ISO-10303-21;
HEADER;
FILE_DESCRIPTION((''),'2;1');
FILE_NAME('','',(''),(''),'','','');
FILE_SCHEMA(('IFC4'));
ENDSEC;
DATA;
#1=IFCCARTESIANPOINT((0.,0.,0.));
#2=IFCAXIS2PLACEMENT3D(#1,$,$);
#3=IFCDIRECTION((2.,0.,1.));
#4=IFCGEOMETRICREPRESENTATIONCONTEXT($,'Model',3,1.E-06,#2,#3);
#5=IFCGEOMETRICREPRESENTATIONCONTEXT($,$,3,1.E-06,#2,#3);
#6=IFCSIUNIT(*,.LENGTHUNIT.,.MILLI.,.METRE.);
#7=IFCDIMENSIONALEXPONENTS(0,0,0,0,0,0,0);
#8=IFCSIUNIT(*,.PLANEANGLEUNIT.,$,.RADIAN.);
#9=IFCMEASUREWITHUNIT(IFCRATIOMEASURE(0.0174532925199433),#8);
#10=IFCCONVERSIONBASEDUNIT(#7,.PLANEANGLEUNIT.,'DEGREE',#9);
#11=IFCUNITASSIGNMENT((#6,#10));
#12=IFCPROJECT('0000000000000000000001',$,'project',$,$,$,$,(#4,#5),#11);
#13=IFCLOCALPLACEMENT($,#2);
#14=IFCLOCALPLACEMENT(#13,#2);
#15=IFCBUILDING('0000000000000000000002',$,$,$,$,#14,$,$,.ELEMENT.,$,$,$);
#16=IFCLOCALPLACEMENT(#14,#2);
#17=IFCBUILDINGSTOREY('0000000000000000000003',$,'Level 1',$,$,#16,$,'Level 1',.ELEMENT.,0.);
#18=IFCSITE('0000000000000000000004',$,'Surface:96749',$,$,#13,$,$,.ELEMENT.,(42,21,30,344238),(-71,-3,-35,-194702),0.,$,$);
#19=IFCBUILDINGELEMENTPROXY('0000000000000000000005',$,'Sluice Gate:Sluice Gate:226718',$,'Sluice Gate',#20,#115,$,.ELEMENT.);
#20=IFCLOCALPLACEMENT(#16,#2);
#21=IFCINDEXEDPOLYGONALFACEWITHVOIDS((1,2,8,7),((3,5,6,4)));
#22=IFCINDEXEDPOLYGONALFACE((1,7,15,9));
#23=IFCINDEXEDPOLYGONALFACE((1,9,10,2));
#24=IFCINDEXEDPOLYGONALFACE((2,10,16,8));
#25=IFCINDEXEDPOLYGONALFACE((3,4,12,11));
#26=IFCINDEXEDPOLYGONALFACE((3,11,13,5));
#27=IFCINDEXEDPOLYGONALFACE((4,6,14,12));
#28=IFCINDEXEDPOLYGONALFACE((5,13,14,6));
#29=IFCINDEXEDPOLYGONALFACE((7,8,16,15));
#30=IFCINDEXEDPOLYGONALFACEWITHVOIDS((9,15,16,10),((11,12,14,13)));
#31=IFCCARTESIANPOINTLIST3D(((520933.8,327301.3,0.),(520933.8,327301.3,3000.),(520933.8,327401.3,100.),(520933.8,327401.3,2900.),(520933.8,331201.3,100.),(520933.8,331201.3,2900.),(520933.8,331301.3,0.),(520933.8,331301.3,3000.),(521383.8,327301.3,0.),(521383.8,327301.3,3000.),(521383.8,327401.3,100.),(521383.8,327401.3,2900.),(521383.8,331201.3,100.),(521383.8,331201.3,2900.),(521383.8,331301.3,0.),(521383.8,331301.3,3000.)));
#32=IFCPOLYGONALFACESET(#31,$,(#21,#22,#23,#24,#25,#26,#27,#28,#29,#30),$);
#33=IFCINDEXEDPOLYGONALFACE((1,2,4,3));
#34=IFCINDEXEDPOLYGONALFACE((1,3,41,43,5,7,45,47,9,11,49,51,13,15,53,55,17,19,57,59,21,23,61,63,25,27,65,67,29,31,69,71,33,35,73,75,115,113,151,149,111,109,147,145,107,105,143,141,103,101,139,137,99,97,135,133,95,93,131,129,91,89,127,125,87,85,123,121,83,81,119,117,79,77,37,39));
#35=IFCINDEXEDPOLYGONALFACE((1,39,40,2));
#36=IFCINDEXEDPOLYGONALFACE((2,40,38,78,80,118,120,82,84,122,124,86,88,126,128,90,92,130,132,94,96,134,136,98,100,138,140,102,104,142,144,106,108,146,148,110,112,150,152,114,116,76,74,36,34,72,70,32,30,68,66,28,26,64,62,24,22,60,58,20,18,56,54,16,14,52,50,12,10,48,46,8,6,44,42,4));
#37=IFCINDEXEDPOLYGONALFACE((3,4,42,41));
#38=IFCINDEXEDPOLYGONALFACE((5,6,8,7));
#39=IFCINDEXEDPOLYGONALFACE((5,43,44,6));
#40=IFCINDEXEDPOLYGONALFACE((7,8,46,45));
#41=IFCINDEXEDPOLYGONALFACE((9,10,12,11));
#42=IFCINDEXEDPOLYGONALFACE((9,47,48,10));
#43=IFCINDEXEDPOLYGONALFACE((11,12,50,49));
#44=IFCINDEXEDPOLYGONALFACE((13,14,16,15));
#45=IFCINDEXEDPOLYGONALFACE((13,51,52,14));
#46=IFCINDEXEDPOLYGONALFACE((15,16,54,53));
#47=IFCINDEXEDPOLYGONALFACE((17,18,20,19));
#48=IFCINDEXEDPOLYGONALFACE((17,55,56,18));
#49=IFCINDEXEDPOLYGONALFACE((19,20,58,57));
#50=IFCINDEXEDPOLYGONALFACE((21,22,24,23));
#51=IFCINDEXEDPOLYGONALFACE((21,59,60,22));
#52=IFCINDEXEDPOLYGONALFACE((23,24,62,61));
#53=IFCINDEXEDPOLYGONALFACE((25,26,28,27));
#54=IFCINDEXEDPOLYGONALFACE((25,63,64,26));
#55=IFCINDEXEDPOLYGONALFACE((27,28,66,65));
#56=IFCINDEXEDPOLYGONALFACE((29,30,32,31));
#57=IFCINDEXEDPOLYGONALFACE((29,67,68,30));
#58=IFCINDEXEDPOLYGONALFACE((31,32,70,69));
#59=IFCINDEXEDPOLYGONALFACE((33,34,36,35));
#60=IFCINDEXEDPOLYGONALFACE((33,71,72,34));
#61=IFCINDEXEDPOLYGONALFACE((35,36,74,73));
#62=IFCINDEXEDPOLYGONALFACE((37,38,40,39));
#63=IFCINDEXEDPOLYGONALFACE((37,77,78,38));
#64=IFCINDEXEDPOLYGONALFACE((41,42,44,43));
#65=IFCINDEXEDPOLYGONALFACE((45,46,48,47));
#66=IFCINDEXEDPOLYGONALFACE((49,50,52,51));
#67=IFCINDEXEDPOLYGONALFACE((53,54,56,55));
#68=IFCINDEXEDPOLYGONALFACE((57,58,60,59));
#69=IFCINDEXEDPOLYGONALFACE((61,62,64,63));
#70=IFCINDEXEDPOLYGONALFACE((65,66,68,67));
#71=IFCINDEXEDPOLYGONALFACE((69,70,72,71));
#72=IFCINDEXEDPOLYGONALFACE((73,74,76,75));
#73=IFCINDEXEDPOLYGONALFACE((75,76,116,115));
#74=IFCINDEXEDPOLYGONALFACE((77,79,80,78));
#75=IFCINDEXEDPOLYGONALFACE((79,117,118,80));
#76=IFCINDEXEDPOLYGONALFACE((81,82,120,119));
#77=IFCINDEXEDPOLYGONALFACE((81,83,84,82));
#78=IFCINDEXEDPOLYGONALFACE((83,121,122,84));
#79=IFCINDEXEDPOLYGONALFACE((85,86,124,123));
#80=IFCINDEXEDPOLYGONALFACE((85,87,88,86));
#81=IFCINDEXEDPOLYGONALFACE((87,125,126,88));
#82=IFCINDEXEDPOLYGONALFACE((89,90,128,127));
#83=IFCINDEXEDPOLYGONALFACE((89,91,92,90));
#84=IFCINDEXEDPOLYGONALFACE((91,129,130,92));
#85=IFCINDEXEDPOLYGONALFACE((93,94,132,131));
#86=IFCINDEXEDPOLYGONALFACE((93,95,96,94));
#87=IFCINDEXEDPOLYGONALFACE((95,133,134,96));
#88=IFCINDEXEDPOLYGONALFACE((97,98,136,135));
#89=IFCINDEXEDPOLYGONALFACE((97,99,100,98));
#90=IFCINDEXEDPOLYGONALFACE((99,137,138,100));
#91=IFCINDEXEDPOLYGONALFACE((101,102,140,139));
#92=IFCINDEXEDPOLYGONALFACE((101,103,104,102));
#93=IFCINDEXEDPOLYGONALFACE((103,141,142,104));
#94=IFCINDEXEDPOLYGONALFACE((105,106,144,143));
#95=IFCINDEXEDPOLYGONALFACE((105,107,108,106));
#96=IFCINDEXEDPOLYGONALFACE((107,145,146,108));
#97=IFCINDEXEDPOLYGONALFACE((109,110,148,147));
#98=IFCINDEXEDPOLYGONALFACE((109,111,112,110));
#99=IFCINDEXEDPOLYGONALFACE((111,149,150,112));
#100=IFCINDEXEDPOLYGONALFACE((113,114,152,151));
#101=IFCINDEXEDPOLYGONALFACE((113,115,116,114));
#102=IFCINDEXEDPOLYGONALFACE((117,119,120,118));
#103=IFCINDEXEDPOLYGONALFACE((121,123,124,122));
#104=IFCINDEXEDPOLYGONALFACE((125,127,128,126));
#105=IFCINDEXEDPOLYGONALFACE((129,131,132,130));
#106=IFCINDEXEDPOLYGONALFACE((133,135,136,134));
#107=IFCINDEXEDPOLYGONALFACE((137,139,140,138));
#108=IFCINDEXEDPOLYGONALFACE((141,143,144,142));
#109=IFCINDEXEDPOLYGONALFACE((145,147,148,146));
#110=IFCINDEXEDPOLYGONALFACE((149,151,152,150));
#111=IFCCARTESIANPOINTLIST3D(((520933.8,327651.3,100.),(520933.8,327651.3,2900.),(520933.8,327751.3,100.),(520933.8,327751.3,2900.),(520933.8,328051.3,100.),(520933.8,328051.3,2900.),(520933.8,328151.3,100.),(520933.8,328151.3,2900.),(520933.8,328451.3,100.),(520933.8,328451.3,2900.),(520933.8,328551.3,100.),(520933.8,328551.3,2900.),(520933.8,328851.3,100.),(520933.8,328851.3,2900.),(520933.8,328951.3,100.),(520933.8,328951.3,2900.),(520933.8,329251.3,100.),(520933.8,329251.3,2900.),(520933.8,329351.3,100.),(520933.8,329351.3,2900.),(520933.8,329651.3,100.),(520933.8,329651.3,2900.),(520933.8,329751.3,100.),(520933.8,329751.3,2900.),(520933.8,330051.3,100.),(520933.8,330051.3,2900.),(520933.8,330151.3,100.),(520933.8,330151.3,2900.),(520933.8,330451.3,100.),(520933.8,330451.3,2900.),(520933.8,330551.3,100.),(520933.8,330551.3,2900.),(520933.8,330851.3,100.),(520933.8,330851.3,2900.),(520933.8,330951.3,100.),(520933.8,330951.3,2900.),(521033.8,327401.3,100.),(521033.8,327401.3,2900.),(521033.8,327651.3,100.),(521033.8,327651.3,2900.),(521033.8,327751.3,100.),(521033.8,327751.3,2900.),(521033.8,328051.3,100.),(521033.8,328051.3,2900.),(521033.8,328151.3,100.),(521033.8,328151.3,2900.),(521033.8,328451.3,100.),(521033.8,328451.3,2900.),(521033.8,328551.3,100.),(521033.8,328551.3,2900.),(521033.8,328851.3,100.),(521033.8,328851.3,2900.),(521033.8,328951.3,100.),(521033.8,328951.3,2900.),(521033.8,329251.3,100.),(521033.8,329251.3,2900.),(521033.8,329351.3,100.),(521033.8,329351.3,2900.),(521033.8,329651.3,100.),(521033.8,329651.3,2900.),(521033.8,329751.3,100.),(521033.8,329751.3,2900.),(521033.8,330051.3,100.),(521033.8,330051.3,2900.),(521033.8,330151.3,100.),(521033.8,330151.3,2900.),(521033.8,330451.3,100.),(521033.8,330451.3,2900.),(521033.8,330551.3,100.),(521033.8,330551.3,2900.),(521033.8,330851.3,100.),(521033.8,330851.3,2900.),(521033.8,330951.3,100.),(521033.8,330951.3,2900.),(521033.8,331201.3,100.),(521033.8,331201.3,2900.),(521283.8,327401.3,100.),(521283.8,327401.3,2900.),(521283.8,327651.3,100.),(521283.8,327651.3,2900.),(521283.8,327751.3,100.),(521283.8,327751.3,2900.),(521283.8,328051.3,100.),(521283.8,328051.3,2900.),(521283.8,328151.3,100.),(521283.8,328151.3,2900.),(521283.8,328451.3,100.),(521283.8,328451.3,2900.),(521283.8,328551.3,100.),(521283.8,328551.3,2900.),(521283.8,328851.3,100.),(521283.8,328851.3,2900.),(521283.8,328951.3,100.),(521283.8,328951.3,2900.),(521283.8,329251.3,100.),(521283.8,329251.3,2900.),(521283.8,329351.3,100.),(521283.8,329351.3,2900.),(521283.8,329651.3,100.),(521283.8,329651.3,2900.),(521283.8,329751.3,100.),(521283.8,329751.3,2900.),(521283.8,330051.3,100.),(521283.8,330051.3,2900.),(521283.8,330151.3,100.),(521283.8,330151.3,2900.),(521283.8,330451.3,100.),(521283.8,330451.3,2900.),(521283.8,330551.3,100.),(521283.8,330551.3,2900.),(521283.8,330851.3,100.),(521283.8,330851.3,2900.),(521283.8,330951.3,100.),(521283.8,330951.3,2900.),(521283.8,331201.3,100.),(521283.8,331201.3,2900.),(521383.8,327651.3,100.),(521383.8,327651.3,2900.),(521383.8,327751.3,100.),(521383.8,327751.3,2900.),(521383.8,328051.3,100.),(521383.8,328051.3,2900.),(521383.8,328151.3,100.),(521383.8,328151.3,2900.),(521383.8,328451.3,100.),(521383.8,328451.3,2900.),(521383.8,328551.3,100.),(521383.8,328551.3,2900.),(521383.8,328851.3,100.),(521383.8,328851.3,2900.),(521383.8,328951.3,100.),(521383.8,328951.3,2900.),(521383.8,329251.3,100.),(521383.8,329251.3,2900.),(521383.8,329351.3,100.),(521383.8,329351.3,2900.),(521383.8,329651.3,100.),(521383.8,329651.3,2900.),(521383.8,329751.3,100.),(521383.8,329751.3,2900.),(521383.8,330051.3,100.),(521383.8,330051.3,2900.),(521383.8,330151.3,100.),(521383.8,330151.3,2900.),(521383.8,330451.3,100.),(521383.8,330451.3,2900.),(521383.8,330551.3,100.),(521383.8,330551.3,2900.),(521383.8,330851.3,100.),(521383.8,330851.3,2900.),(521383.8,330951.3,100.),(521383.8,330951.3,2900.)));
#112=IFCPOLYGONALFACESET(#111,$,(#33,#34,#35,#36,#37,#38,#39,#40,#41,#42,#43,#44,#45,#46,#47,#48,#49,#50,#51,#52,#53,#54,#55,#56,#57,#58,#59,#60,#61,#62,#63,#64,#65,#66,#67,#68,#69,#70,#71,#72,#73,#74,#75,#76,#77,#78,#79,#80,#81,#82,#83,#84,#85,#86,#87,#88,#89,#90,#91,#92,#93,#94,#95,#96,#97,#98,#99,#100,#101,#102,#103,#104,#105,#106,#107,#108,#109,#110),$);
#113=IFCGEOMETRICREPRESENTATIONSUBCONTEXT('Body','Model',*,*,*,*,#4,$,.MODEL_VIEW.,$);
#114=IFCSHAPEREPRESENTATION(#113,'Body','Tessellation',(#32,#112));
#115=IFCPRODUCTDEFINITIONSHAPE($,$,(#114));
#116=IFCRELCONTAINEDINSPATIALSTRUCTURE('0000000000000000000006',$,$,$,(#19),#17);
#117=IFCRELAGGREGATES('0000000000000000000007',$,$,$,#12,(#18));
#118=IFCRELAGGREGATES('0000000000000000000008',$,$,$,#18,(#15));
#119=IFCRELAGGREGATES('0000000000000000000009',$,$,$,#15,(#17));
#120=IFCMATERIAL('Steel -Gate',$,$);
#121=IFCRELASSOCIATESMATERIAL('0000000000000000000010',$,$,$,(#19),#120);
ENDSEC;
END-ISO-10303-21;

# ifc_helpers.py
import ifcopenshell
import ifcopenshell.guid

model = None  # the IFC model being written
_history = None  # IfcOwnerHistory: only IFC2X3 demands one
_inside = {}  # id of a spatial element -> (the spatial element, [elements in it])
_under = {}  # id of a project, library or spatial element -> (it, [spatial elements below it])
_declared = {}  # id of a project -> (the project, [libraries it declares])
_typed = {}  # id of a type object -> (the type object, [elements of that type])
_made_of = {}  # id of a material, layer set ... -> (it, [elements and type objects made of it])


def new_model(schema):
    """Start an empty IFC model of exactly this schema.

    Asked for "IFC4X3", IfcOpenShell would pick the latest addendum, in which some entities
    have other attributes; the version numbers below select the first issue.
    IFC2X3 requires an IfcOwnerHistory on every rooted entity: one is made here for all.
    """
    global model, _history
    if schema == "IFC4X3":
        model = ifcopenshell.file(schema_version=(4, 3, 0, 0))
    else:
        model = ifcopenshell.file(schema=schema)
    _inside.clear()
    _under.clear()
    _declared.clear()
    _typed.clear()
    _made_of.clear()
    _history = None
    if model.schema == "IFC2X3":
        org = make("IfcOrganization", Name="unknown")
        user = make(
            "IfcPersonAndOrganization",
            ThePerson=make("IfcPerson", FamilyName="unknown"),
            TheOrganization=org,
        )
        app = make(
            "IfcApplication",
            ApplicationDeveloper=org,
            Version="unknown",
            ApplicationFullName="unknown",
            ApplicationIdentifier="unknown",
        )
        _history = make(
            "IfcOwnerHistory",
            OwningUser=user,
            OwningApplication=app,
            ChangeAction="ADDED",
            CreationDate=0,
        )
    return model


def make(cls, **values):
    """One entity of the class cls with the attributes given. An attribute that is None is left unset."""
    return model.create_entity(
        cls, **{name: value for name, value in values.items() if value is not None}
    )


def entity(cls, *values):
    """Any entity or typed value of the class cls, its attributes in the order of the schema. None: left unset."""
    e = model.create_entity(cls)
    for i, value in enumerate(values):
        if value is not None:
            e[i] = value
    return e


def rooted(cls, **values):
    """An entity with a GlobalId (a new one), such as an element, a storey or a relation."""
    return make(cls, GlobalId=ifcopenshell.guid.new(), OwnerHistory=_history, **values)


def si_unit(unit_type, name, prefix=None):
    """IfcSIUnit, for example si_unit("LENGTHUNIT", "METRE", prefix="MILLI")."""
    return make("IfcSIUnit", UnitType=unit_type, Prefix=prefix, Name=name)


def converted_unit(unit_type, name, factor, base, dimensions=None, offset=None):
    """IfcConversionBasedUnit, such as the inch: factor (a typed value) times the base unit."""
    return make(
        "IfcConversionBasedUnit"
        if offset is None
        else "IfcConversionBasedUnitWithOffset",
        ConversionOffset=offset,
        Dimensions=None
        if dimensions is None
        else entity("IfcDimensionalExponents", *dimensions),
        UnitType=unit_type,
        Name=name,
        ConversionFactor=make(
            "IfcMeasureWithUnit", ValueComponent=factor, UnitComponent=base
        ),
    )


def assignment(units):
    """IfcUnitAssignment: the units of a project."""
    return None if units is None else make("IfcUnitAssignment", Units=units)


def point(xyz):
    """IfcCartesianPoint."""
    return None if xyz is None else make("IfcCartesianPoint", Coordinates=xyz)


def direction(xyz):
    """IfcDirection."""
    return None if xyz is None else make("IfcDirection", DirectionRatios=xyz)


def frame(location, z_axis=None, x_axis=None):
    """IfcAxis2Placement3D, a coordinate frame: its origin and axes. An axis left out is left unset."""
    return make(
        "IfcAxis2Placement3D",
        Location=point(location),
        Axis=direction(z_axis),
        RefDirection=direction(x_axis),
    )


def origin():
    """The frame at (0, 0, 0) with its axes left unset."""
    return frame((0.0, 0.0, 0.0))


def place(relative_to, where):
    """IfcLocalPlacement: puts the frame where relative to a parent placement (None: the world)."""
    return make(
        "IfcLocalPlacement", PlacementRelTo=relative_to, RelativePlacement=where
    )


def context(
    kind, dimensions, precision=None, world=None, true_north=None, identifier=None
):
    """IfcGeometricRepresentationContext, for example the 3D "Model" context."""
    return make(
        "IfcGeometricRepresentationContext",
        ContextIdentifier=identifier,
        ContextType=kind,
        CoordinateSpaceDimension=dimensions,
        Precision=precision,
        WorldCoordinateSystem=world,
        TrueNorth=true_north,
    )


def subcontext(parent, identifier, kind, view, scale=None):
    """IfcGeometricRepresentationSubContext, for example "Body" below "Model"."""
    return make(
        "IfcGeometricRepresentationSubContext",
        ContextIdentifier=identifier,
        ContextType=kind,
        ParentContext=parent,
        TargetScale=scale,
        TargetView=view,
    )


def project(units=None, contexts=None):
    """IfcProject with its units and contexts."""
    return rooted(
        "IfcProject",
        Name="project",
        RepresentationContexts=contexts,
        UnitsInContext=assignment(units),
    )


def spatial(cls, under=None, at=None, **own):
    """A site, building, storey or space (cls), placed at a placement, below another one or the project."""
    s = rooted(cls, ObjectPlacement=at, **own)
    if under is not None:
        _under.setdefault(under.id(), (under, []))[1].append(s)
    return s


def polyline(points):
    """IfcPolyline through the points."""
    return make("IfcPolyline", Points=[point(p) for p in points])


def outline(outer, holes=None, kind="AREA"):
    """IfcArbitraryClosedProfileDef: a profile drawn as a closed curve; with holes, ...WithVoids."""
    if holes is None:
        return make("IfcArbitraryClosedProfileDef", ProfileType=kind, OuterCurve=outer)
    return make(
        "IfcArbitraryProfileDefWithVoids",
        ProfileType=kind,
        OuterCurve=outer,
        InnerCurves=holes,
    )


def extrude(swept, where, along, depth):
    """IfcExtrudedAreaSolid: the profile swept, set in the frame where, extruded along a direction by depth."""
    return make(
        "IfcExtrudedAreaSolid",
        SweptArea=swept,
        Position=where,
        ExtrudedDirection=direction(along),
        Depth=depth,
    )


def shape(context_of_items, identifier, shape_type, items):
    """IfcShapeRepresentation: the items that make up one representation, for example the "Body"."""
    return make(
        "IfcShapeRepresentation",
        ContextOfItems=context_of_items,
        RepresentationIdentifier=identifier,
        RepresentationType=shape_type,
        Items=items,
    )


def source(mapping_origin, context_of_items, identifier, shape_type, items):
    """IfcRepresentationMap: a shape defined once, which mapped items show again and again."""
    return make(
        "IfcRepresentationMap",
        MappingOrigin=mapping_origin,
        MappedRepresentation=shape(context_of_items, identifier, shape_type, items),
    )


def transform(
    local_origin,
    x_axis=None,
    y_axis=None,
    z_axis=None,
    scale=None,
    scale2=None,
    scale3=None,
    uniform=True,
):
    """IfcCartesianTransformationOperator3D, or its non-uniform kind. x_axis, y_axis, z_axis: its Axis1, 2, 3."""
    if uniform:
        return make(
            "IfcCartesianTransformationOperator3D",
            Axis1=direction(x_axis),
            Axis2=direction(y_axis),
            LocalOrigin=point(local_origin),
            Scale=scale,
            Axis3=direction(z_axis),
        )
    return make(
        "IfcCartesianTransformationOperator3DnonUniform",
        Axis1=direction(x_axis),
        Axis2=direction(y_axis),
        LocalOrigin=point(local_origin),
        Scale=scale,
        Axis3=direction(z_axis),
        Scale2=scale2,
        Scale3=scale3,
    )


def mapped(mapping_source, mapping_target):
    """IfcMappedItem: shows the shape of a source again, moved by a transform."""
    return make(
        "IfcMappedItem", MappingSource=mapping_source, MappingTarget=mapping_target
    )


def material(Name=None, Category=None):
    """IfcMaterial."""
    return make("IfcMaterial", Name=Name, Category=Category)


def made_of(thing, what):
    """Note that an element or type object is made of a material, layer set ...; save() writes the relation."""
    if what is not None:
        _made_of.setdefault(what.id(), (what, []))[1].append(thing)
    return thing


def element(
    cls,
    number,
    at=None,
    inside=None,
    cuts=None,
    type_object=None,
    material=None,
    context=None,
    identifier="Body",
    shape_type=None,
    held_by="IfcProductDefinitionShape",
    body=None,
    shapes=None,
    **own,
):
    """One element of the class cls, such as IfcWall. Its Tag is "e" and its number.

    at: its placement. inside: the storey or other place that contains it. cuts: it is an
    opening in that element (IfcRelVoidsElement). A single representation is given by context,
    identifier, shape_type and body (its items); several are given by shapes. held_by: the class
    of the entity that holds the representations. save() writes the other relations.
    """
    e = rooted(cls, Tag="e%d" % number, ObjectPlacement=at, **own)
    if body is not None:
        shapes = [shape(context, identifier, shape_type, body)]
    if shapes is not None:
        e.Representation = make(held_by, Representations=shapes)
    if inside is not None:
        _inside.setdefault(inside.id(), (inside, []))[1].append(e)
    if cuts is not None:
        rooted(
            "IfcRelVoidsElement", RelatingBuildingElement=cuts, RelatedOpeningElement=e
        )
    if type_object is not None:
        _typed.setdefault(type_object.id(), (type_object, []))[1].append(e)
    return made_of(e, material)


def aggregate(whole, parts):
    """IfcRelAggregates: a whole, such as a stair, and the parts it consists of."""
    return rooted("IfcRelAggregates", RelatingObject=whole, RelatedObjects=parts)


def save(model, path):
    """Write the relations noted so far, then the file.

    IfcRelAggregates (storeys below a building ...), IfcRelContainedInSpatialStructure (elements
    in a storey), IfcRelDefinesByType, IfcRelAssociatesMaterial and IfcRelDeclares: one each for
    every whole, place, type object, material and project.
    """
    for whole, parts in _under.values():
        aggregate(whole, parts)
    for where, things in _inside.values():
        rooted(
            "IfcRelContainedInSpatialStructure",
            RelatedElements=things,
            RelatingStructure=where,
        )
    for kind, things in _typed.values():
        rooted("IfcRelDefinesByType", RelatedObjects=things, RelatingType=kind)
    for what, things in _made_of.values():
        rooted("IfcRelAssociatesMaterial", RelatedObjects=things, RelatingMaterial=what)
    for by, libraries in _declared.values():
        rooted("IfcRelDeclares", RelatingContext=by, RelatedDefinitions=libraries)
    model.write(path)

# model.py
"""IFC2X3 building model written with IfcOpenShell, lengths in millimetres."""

from ifc_helpers import new_model, entity, si_unit, converted_unit, direction, frame, origin, place, context, subcontext, project, spatial, polyline, outline, extrude, source, transform, mapped, material, element, save


model = new_model("IFC2X3")

# Units and contexts
model_context = context("Model", 3, precision=1e-06, world=origin(), true_north=direction((2.0, 0.0, 1.0)))
context_of_model = context(None, 3, precision=1e-06, world=origin(), true_north=direction((2.0, 0.0, 1.0)))
body_context = subcontext(model_context, "Body", "Model", "MODEL_VIEW")
ifc_project = project(units=[si_unit("LENGTHUNIT", "METRE", prefix="MILLI"), converted_unit("PLANEANGLEUNIT", "DEGREE", entity("IfcRatioMeasure", 0.0174532925199433), si_unit("PLANEANGLEUNIT", "RADIAN"), dimensions=[0, 0, 0, 0, 0, 0, 0])], contexts=[model_context, context_of_model])

# Site, building, storey
site_placement = place(None, origin())
site = spatial("IfcSite", under=ifc_project, at=site_placement, Name="Surface:96749", CompositionType="ELEMENT", RefLatitude=(42, 21, 30, 344238), RefLongitude=(-71, -3, -35, -194702), RefElevation=0.0)
building_placement = place(site_placement, origin())
building = spatial("IfcBuilding", under=site, at=building_placement, CompositionType="ELEMENT")
storey_placement = place(building_placement, origin())
storey = spatial("IfcBuildingStorey", under=building, at=storey_placement, Name="Level 1", LongName="Level 1", CompositionType="ELEMENT", Elevation=0.0)

# Building element proxy
ifc_material = material(Name="Steel -Gate")
shared_shape_1 = source(origin(), body_context, "Body", "SweptSolid", [
    extrude(outline(polyline([(-1500.0, -2000.0), (1500.0, -2000.0), (1500.0, 2000.0), (-1500.0, 2000.0), (-1500.0, -2000.0)]), holes=[polyline([(1400.0, -1900.0), (-1400.0, -1900.0), (-1400.0, 1900.0), (1400.0, 1900.0), (1400.0, -1900.0)])]), frame((0.0, -225.0, 1500.0), z_axis=(0.0, 1.0, 0.0), x_axis=(0.0, 0.0, -1.0)), (0.0, 0.0, 1.0), 450.0),
    extrude(outline(polyline([(1650.0, -125.0), (1900.0, -125.0), (1900.0, 125.0), (1650.0, 125.0), (1650.0, 225.0), (1550.0, 225.0), (1550.0, 125.0), (1250.0, 125.0), (1250.0, 225.0), (1150.0, 225.0), (1150.0, 125.0), (850.0, 125.0), (850.0, 225.0), (750.0, 225.0), (750.0, 125.0), (450.0, 125.0), (450.0, 225.0), (350.0, 225.0), (350.0, 125.0), (50.0, 125.0), (50.0, 225.0), (-50.0, 225.0), (-50.0, 125.0), (-350.0, 125.0), (-350.0, 225.0), (-450.0, 225.0), (-450.0, 125.0), (-750.0, 125.0), (-750.0, 225.0), (-850.0, 225.0), (-850.0, 125.0), (-1150.0, 125.0), (-1150.0, 225.0), (-1250.0, 225.0), (-1250.0, 125.0), (-1550.0, 125.0), (-1550.0, 225.0), (-1650.0, 225.0), (-1650.0, 125.0), (-1900.0, 125.0), (-1900.0, -125.0), (-1650.0, -125.0), (-1650.0, -225.0), (-1550.0, -225.0), (-1550.0, -125.0), (-1250.0, -125.0), (-1250.0, -225.0), (-1150.0, -225.0), (-1150.0, -125.0), (-850.0, -125.0), (-850.0, -225.0), (-750.0, -225.0), (-750.0, -125.0), (-450.0, -125.0), (-450.0, -225.0), (-350.0, -225.0), (-350.0, -125.0), (-50.0, -125.0), (-50.0, -225.0), (50.0, -225.0), (50.0, -125.0), (350.0, -125.0), (350.0, -225.0), (450.0, -225.0), (450.0, -125.0), (750.0, -125.0), (750.0, -225.0), (850.0, -225.0), (850.0, -125.0), (1150.0, -125.0), (1150.0, -225.0), (1250.0, -225.0), (1250.0, -125.0), (1550.0, -125.0), (1550.0, -225.0), (1650.0, -225.0), (1650.0, -125.0)])), frame((0.0, 0.0, 100.0), z_axis=(0.0, 0.0, 1.0), x_axis=(-1.0, 0.0, 0.0)), (0.0, 0.0, 1.0), 2800.0),
])
for number, where, z_axis, x_axis, name in (
    (1, (521158.8, 329301.3, 0.0), (0.0, 0.0, 1.0), (0.0, 1.0, 0.0), "Sluice Gate:Sluice Gate:226718"),
):
    element("IfcBuildingElementProxy", number, at=place(storey_placement, frame(where, z_axis=z_axis, x_axis=x_axis)), inside=storey, material=ifc_material, Name=name, ObjectType="Sluice Gate", CompositionType="ELEMENT", context=body_context, shape_type="MappedRepresentation", body=[
        mapped(shared_shape_1, transform((0.0, 0.0, 0.0), scale=1.0)),
    ])

save(model, "model.ifc")
